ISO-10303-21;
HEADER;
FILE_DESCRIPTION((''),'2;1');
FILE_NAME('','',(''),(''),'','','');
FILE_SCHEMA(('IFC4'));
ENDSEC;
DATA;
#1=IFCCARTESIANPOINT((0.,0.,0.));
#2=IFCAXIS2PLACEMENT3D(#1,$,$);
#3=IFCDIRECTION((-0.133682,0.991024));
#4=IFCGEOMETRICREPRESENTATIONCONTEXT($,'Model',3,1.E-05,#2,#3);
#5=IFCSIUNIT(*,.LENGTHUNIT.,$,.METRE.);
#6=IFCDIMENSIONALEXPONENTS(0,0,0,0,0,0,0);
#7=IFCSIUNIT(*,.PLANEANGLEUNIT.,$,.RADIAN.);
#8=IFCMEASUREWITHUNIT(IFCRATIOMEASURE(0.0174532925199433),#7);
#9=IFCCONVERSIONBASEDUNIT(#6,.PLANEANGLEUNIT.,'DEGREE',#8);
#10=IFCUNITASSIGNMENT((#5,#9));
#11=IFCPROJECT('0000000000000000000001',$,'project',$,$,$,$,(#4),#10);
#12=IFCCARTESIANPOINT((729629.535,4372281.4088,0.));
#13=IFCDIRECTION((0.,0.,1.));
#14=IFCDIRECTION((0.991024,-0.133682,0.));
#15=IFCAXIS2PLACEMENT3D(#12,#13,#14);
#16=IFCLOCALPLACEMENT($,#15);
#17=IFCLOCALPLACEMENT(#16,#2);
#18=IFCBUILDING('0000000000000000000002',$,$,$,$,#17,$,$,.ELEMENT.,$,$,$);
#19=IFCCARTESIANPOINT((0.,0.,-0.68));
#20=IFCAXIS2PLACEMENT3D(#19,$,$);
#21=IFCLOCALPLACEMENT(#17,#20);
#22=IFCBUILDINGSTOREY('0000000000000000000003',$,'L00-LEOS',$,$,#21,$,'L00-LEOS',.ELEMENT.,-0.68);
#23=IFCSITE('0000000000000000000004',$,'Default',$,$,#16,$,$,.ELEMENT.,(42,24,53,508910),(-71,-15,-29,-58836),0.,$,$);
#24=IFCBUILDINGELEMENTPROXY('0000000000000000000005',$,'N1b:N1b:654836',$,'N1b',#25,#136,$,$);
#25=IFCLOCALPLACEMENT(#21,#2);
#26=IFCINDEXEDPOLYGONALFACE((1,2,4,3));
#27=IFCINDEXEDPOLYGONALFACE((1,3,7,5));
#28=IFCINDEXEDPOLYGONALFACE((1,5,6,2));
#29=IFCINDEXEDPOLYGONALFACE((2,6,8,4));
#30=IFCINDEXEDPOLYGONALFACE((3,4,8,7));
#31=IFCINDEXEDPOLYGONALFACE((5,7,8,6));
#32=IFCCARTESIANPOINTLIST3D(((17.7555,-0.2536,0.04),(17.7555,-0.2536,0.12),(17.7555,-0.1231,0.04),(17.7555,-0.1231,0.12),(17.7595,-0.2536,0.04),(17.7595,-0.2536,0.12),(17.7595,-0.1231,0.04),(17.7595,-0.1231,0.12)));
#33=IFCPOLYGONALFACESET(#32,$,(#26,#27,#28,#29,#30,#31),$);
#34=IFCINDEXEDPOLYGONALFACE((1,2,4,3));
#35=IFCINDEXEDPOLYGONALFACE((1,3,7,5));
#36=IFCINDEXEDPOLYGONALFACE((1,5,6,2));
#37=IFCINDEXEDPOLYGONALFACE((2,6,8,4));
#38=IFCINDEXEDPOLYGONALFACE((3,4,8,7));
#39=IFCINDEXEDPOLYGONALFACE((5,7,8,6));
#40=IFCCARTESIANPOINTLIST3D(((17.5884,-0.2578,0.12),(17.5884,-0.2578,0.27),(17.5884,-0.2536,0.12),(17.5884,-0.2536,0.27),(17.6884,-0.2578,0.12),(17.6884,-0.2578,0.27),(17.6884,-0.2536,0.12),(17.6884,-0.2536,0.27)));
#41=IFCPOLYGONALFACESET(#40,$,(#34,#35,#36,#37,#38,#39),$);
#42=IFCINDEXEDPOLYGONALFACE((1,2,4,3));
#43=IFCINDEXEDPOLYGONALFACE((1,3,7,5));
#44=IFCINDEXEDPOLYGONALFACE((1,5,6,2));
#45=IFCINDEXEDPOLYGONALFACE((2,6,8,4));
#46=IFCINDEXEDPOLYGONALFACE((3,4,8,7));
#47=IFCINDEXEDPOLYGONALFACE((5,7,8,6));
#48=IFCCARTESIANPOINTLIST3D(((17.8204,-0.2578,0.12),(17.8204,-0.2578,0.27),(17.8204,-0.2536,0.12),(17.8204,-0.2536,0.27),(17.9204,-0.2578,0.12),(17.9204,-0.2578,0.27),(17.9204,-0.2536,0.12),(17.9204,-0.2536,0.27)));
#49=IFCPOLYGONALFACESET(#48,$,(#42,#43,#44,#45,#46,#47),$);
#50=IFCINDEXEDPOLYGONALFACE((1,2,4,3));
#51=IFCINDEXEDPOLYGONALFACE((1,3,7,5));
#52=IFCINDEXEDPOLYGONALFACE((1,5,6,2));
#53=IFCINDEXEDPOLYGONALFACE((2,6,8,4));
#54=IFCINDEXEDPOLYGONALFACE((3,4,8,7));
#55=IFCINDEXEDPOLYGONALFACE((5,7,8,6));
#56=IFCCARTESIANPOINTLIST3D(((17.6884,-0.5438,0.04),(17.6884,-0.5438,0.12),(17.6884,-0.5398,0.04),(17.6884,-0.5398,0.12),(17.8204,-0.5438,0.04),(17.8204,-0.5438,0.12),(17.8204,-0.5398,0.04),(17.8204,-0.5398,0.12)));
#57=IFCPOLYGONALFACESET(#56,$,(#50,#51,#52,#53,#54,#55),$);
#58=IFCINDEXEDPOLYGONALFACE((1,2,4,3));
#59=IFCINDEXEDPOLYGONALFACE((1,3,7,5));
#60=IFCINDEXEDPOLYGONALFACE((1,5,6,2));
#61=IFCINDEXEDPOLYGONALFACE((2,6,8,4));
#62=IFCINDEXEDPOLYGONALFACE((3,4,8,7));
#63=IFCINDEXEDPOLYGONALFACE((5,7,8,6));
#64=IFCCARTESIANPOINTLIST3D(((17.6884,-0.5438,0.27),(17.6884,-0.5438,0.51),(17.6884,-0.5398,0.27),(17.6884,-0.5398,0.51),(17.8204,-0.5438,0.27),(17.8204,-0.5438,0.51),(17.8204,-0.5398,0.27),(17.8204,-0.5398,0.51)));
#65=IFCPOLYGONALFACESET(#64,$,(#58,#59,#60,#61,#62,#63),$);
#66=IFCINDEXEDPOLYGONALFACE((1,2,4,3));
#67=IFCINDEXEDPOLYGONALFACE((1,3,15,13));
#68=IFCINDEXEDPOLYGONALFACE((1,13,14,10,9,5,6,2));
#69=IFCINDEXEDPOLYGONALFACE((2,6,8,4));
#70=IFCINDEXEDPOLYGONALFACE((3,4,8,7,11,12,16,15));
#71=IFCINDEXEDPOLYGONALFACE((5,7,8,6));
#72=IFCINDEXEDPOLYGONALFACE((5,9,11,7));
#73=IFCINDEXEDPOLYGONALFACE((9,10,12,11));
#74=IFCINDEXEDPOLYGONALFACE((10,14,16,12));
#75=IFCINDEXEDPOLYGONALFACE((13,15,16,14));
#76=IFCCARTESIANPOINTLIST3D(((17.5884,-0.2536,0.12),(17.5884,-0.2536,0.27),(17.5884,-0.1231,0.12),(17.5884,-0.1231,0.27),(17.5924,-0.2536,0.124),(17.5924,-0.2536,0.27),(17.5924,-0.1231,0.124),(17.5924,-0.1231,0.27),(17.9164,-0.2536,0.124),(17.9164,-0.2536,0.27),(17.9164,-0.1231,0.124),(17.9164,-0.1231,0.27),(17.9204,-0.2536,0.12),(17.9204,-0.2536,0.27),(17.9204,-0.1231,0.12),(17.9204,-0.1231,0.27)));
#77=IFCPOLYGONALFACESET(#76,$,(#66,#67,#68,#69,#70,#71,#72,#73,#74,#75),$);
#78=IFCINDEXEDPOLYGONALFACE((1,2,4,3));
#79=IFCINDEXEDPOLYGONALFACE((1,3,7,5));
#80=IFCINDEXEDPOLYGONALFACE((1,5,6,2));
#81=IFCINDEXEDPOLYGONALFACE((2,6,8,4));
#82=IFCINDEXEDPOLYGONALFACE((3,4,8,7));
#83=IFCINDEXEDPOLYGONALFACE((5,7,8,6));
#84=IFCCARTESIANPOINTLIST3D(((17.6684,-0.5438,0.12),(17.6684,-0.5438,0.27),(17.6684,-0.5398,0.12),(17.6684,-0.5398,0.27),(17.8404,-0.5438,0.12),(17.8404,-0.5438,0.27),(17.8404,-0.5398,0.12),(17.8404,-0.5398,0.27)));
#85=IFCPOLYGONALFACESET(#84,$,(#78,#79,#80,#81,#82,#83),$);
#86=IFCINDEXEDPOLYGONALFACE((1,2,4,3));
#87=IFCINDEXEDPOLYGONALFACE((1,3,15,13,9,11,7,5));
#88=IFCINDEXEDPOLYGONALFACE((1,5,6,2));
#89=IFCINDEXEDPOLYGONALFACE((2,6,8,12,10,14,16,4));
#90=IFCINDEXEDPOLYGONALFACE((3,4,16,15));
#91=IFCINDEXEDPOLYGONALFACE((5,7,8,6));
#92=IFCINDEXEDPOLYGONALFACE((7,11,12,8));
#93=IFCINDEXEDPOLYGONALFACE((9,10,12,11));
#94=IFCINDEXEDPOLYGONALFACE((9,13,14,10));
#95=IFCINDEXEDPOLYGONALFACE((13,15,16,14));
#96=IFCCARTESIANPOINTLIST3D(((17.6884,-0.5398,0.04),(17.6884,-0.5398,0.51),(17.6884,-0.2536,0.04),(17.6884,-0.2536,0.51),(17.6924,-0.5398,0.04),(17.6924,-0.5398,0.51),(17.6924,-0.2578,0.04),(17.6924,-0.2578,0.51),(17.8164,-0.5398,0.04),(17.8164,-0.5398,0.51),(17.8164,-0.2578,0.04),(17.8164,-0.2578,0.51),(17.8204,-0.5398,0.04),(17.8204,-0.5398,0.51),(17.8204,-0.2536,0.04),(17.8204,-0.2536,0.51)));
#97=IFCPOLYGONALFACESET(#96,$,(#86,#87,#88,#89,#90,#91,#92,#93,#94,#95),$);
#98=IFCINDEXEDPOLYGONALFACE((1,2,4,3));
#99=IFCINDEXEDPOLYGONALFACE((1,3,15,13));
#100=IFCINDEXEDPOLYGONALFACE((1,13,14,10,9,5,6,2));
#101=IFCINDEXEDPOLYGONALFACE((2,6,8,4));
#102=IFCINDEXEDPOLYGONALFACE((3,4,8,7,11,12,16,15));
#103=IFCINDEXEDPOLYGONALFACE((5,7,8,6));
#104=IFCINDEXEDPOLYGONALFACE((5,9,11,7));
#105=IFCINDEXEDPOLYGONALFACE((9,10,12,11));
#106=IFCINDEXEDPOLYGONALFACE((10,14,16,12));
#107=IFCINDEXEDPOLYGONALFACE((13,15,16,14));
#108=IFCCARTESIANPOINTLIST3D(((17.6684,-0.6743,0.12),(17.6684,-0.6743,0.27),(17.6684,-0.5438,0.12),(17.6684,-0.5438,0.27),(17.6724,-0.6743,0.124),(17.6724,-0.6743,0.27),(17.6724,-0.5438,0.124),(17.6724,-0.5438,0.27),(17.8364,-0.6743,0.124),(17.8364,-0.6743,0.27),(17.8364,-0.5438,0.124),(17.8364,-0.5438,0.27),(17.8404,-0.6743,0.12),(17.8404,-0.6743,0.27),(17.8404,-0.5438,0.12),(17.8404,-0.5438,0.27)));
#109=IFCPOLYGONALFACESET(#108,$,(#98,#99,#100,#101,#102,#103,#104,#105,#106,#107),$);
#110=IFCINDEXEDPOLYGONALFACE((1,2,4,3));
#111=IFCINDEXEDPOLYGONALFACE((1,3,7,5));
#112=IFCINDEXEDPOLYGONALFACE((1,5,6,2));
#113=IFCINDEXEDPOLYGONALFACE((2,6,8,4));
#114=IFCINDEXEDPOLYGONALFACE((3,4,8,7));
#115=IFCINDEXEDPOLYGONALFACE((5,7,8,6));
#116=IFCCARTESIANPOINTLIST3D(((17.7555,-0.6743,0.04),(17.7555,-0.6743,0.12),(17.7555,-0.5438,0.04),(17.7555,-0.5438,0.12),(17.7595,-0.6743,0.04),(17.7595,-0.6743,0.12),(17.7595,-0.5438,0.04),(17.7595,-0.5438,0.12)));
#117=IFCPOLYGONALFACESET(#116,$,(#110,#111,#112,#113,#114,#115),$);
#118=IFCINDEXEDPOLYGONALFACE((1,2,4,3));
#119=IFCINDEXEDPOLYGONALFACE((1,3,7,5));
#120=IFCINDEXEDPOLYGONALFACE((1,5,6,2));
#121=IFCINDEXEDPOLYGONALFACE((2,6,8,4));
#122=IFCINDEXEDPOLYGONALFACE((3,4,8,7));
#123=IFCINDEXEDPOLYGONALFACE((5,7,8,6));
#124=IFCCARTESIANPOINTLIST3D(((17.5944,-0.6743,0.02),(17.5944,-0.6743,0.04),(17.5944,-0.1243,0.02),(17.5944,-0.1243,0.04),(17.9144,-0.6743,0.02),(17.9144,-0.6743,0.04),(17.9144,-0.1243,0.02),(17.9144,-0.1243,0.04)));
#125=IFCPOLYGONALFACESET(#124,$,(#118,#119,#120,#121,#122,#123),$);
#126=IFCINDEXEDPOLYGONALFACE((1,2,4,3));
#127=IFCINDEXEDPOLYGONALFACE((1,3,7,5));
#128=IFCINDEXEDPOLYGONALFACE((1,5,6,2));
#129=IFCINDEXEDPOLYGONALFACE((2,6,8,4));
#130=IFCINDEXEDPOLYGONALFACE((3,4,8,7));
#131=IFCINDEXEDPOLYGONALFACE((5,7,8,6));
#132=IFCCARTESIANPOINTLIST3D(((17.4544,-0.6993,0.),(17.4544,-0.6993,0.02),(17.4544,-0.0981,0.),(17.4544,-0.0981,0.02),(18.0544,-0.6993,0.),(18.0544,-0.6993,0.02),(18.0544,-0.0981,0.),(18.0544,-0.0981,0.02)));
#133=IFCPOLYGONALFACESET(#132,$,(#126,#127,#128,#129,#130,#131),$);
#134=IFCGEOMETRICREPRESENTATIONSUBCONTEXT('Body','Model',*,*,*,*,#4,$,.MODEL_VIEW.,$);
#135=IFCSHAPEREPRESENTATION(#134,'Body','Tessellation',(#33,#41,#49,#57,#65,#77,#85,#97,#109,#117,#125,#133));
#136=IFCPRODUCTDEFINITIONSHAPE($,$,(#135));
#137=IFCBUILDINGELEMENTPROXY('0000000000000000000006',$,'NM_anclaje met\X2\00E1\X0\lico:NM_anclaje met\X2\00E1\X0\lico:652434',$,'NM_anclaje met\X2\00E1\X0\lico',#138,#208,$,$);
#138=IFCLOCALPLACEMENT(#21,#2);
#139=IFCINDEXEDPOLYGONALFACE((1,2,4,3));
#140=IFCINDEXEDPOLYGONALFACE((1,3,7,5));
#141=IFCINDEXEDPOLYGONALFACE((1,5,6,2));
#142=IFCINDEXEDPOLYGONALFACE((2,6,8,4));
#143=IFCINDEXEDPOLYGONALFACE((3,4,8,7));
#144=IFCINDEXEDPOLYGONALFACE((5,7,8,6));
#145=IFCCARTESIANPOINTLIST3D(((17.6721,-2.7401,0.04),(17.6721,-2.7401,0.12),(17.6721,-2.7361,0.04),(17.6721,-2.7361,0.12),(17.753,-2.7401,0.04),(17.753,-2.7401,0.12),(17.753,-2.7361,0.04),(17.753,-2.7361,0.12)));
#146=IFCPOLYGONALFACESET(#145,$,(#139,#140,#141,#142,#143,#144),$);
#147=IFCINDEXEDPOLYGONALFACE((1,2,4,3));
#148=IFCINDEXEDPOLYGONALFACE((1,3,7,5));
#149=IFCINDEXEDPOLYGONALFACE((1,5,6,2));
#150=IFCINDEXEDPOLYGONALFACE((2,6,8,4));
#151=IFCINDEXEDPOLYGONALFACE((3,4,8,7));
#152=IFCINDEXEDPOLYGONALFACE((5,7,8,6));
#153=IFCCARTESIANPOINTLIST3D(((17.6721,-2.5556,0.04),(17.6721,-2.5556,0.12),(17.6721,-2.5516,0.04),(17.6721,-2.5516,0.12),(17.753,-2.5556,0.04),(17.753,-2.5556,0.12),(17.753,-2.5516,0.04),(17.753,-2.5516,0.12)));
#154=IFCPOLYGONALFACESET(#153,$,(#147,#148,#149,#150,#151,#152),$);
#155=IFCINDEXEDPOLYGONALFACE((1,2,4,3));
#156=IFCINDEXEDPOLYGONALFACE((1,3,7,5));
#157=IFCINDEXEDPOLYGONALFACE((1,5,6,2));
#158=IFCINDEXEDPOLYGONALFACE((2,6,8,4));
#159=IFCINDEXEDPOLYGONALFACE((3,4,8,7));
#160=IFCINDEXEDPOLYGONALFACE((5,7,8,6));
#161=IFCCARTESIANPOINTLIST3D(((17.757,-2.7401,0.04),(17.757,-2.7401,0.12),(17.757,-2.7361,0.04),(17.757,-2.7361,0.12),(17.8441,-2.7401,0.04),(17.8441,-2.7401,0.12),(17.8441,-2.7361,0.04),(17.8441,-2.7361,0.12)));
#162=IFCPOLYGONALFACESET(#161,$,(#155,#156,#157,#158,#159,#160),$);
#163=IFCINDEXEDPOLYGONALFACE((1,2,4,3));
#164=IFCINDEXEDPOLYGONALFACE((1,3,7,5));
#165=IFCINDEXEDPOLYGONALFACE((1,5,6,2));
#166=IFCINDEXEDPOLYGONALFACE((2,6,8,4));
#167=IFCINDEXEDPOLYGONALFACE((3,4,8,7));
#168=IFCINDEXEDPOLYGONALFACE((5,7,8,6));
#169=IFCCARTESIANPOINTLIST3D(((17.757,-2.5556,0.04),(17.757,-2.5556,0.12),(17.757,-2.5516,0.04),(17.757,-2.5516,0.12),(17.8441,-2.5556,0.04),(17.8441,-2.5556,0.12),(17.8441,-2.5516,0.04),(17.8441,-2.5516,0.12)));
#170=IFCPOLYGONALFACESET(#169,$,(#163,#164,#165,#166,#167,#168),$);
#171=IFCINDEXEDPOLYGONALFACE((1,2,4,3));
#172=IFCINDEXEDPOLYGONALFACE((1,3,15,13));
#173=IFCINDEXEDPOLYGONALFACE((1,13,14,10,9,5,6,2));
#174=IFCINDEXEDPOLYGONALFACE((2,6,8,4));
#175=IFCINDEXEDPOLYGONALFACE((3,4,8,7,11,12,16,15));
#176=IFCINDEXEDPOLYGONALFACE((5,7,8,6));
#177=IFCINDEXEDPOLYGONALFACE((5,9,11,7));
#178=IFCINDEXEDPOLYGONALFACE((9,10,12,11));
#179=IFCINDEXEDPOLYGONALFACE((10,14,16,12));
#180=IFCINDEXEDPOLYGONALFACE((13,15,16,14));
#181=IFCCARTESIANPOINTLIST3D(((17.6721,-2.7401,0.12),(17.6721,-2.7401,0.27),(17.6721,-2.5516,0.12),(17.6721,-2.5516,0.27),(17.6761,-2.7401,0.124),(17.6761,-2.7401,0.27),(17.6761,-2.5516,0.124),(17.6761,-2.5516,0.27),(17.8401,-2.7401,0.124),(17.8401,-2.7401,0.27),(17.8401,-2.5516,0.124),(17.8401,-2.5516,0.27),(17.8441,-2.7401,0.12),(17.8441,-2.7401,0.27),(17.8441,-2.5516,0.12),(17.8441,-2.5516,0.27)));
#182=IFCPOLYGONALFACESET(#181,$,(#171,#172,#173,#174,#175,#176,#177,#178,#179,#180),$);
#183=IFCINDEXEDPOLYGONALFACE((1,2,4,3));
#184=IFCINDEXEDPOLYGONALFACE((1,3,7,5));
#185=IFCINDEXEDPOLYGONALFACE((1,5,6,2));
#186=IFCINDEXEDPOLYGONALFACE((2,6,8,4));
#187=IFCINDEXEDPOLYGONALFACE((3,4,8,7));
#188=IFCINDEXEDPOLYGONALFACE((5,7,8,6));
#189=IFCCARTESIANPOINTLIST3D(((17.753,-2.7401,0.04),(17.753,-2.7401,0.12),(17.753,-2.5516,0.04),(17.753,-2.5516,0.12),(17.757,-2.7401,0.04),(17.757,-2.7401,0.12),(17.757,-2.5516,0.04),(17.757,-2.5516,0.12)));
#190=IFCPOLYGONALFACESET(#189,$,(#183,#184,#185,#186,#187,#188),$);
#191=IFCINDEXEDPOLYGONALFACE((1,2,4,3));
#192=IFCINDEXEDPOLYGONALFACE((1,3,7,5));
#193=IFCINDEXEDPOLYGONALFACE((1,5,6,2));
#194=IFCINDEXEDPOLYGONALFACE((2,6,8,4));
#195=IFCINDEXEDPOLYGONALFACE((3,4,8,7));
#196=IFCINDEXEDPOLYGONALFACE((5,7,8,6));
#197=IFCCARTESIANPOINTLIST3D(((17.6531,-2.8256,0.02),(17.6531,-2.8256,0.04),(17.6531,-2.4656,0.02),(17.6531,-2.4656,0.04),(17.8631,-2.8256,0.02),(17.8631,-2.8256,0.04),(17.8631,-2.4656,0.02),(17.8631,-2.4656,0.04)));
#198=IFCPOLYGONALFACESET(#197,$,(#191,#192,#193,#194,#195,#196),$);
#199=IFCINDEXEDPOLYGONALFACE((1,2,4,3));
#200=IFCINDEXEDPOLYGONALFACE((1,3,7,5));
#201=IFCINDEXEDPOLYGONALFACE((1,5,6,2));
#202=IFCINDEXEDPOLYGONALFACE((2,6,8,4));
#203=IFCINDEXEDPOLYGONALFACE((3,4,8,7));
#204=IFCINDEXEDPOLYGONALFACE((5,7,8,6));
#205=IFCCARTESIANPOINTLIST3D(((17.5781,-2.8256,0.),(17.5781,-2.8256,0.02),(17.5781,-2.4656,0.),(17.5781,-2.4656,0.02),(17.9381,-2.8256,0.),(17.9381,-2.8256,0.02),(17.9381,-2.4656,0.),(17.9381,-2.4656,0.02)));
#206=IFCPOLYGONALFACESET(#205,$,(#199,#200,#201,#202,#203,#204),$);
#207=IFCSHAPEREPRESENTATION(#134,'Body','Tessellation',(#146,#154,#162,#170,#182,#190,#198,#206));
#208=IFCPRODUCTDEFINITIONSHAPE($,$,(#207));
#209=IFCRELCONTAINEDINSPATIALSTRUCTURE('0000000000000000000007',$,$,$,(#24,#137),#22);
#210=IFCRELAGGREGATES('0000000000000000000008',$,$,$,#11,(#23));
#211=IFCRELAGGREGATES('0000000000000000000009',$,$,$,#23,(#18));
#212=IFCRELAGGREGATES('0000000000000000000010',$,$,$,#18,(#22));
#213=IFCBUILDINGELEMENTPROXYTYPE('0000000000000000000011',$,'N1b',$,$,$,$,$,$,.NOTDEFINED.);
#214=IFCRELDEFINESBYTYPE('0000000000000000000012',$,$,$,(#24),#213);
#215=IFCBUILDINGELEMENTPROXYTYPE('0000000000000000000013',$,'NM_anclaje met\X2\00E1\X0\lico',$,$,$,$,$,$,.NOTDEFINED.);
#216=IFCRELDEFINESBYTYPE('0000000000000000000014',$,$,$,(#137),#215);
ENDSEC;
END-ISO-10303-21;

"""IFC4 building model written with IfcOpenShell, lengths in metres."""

from ifc_helpers import new_model, entity, si_unit, converted_unit, direction, frame, frame_2d, origin, origin_2d_with_axis, place, context, subcontext, project, spatial, polyline, rectangle, outline, extrude, source, transform, mapped, type_object, type_shapes, element, save


model = new_model("IFC4")

# Units and contexts
model_context = context("Model", 3, precision=1e-05, world=origin(), true_north=direction((-0.133682, 0.991024)))
body_context = subcontext(model_context, "Body", "Model", "MODEL_VIEW")
ifc_project = project(units=[si_unit("LENGTHUNIT", "METRE"), converted_unit("PLANEANGLEUNIT", "DEGREE", entity("IfcRatioMeasure", 0.0174532925199433), si_unit("PLANEANGLEUNIT", "RADIAN"), dimensions=[0, 0, 0, 0, 0, 0, 0])], contexts=[model_context])

# Site, building, storey
site_placement = place(None, frame((729629.535, 4372281.4088, 0.0), z_axis=(0.0, 0.0, 1.0), x_axis=(0.991024, -0.133682, 0.0)))
site = spatial("IfcSite", under=ifc_project, at=site_placement, Name="Default", CompositionType="ELEMENT", RefLatitude=(42, 24, 53, 508910), RefLongitude=(-71, -15, -29, -58836), RefElevation=0.0)
building_placement = place(site_placement, origin())
building = spatial("IfcBuilding", under=site, at=building_placement, CompositionType="ELEMENT")
storey_placement = place(building_placement, frame((0.0, 0.0, -0.68)))
storey = spatial("IfcBuildingStorey", under=building, at=storey_placement, Name="L00-LEOS", LongName="L00-LEOS", CompositionType="ELEMENT", Elevation=-0.68)

# Building element proxies
building_element_proxy_type_1 = type_object("IfcBuildingElementProxyType", Name="N1b")
shared_shape_1 = source(origin(), body_context, "Body", "SweptSolid", [
    extrude(rectangle(XDim=0.004, YDim=0.1305, at=origin_2d_with_axis()), frame((0.2103, 0.0, 0.04), z_axis=(0.0, 0.0, 1.0), x_axis=(0.0, -1.0, 0.0)), (0.0, 0.0, 1.0), 0.08),
    extrude(rectangle(XDim=0.1, YDim=0.0042, at=frame_2d((0.0, 0.0), x_axis=(1.0, 0.0))), frame((0.143, 0.1191, 0.12), z_axis=(0.0, 0.0, 1.0), x_axis=(0.0, 1.0, 0.0)), (0.0, 0.0, 1.0), 0.15),
    extrude(rectangle(XDim=0.1, YDim=0.0042, at=origin_2d_with_axis()), frame((0.143, -0.1129, 0.12), z_axis=(0.0, 0.0, 1.0), x_axis=(0.0, 1.0, 0.0)), (0.0, 0.0, 1.0), 0.15),
    extrude(rectangle(XDim=0.132, YDim=0.004, at=frame_2d((0.0, 0.0), x_axis=(1.0, 0.0))), frame((-0.1431, 0.0031, 0.04), z_axis=(0.0, 0.0, 1.0), x_axis=(0.0, 1.0, 0.0)), (0.0, 0.0, 1.0), 0.08),
    extrude(rectangle(XDim=0.132, YDim=0.004, at=frame_2d((0.0, 0.0), x_axis=(1.0, 0.0))), frame((-0.1431, 0.0031, 0.27), z_axis=(0.0, 0.0, 1.0), x_axis=(0.0, 1.0, 0.0)), (0.0, 0.0, 1.0), 0.24),
    extrude(outline(polyline([(-0.076, -0.166), (0.074, -0.166), (0.074, -0.162), (-0.072, -0.162), (-0.072, 0.162), (0.074, 0.162), (0.074, 0.166), (-0.076, 0.166), (-0.076, -0.166)])), frame((0.1451, 0.0031, 0.196), z_axis=(1.0, 0.0, 0.0), x_axis=(0.0, 0.0, 1.0)), (0.0, 0.0, 1.0), 0.1305),
    extrude(rectangle(XDim=0.172, YDim=0.004, at=frame_2d((0.0, 0.0), x_axis=(1.0, 0.0))), frame((-0.1431, 0.0031, 0.12), z_axis=(0.0, 0.0, 1.0), x_axis=(0.0, 1.0, 0.0)), (0.0, 0.0, 1.0), 0.15),
    extrude(outline(polyline([(-0.1441, -0.066), (0.142, -0.066), (0.142, -0.062), (-0.14, -0.062), (-0.14, 0.062), (0.142, 0.062), (0.142, 0.066), (-0.1441, 0.066), (-0.1441, -0.066)])), frame((0.001, 0.0031, 0.04), z_axis=(0.0, 0.0, 1.0), x_axis=(-1.0, 0.0, 0.0)), (0.0, 0.0, 1.0), 0.47),
    extrude(outline(polyline([(-0.076, -0.086), (0.074, -0.086), (0.074, -0.082), (-0.072, -0.082), (-0.072, 0.082), (0.074, 0.082), (0.074, 0.086), (-0.076, 0.086), (-0.076, -0.086)])), frame((-0.2756, 0.0031, 0.196), z_axis=(1.0, 0.0, 0.0), x_axis=(0.0, 0.0, 1.0)), (0.0, 0.0, 1.0), 0.1305),
    extrude(rectangle(XDim=0.004, YDim=0.1305, at=origin_2d_with_axis()), frame((-0.2103, 0.0, 0.04), z_axis=(0.0, 0.0, 1.0), x_axis=(0.0, -1.0, 0.0)), (0.0, 0.0, 1.0), 0.08),
    extrude(rectangle(XDim=0.55, YDim=0.32, at=frame_2d((0.0, 0.0), x_axis=(1.0, 0.0))), frame((-0.0006, 0.0031, 0.02), z_axis=(0.0, 0.0, 1.0), x_axis=(-1.0, 0.0, 0.0)), (0.0, 0.0, 1.0), 0.02),
    extrude(rectangle(XDim=0.6012, YDim=0.6, at=frame_2d((0.0, 0.0), x_axis=(1.0, 0.0))), frame((0.0, 0.0031, 0.0), z_axis=(0.0, 0.0, 1.0), x_axis=(-1.0, 0.0, 0.0)), (0.0, 0.0, 1.0), 0.02),
])
type_shapes(building_element_proxy_type_1, [shared_shape_1])
for number, where, z_axis, x_axis, name in (
    (1, (17.7575, -0.3987, 0.0), (0.0, 0.0, 1.0), (0.0, 1.0, 0.0), "N1b:N1b:654836"),
):
    element("IfcBuildingElementProxy", number, at=place(storey_placement, frame(where, z_axis=z_axis, x_axis=x_axis)), inside=storey, type_object=building_element_proxy_type_1, Name=name, ObjectType="N1b", context=body_context, shape_type="MappedRepresentation", body=[
        mapped(shared_shape_1, transform((0.0, 0.0, 0.0), scale=1.0)),
    ])
building_element_proxy_type_2 = type_object("IfcBuildingElementProxyType", Name="NM_anclaje metálico")
shared_shape_2 = source(origin(), body_context, "Body", "SweptSolid", [
    extrude(rectangle(XDim=0.0809, YDim=0.004, at=frame_2d((0.0, 0.0), x_axis=(1.0, 0.0))), frame((0.0925, -0.0424, 0.04), z_axis=(0.0, 0.0, 1.0), x_axis=(0.0, 1.0, 0.0)), (0.0, 0.0, 1.0), 0.08),
    extrude(rectangle(XDim=0.0809, YDim=0.004, at=frame_2d((0.0, 0.0), x_axis=(1.0, 0.0))), frame((-0.092, -0.0424, 0.04), z_axis=(0.0, 0.0, 1.0), x_axis=(0.0, 1.0, 0.0)), (0.0, 0.0, 1.0), 0.08),
    extrude(rectangle(XDim=0.0871, YDim=0.004, at=origin_2d_with_axis()), frame((0.0925, 0.0456, 0.04), z_axis=(0.0, 0.0, 1.0), x_axis=(0.0, 1.0, 0.0)), (0.0, 0.0, 1.0), 0.08),
    extrude(rectangle(XDim=0.0871, YDim=0.004, at=frame_2d((0.0, 0.0), x_axis=(1.0, 0.0))), frame((-0.092, 0.0456, 0.04), z_axis=(0.0, 0.0, 1.0), x_axis=(0.0, 1.0, 0.0)), (0.0, 0.0, 1.0), 0.08),
    extrude(outline(polyline([(-0.076, -0.086), (0.074, -0.086), (0.074, -0.082), (-0.072, -0.082), (-0.072, 0.082), (0.074, 0.082), (0.074, 0.086), (-0.076, 0.086), (-0.076, -0.086)])), frame((-0.094, 0.0031, 0.196), z_axis=(1.0, 0.0, 0.0), x_axis=(0.0, 0.0, 1.0)), (0.0, 0.0, 1.0), 0.1885),
    extrude(rectangle(XDim=0.004, YDim=0.1885, at=frame_2d((0.0, 0.0), x_axis=(1.0, 0.0))), frame((0.0002, 0.0, 0.04), z_axis=(0.0, 0.0, 1.0), x_axis=(0.0, -1.0, 0.0)), (0.0, 0.0, 1.0), 0.08),
    extrude(rectangle(XDim=0.36, YDim=0.21, at=frame_2d((0.0, 0.0), x_axis=(1.0, 0.0))), frame((0.0, 0.0031, 0.02), z_axis=(0.0, 0.0, 1.0), x_axis=(-1.0, 0.0, 0.0)), (0.0, 0.0, 1.0), 0.02),
    extrude(rectangle(XDim=0.36, YDim=0.36, at=frame_2d((0.0, 0.0), x_axis=(1.0, 0.0))), frame((0.0, 0.0031, 0.0), z_axis=(0.0, 0.0, 1.0), x_axis=(-1.0, 0.0, 0.0)), (0.0, 0.0, 1.0), 0.02),
])
type_shapes(building_element_proxy_type_2, [shared_shape_2])
proxy_1_placement = place(storey_placement, frame((17.755, -2.6456, 0.0), z_axis=(0.0, 0.0, 1.0), x_axis=(0.0, -1.0, 0.0)))
element("IfcBuildingElementProxy", 2, at=proxy_1_placement, inside=storey, type_object=building_element_proxy_type_2, Name="NM_anclaje metálico:NM_anclaje metálico:652434", ObjectType="NM_anclaje metálico", context=body_context, shape_type="MappedRepresentation", body=[
    mapped(shared_shape_2, transform((0.0, 0.0, 0.0), scale=1.0)),
])

save(model, "model.ifc")
